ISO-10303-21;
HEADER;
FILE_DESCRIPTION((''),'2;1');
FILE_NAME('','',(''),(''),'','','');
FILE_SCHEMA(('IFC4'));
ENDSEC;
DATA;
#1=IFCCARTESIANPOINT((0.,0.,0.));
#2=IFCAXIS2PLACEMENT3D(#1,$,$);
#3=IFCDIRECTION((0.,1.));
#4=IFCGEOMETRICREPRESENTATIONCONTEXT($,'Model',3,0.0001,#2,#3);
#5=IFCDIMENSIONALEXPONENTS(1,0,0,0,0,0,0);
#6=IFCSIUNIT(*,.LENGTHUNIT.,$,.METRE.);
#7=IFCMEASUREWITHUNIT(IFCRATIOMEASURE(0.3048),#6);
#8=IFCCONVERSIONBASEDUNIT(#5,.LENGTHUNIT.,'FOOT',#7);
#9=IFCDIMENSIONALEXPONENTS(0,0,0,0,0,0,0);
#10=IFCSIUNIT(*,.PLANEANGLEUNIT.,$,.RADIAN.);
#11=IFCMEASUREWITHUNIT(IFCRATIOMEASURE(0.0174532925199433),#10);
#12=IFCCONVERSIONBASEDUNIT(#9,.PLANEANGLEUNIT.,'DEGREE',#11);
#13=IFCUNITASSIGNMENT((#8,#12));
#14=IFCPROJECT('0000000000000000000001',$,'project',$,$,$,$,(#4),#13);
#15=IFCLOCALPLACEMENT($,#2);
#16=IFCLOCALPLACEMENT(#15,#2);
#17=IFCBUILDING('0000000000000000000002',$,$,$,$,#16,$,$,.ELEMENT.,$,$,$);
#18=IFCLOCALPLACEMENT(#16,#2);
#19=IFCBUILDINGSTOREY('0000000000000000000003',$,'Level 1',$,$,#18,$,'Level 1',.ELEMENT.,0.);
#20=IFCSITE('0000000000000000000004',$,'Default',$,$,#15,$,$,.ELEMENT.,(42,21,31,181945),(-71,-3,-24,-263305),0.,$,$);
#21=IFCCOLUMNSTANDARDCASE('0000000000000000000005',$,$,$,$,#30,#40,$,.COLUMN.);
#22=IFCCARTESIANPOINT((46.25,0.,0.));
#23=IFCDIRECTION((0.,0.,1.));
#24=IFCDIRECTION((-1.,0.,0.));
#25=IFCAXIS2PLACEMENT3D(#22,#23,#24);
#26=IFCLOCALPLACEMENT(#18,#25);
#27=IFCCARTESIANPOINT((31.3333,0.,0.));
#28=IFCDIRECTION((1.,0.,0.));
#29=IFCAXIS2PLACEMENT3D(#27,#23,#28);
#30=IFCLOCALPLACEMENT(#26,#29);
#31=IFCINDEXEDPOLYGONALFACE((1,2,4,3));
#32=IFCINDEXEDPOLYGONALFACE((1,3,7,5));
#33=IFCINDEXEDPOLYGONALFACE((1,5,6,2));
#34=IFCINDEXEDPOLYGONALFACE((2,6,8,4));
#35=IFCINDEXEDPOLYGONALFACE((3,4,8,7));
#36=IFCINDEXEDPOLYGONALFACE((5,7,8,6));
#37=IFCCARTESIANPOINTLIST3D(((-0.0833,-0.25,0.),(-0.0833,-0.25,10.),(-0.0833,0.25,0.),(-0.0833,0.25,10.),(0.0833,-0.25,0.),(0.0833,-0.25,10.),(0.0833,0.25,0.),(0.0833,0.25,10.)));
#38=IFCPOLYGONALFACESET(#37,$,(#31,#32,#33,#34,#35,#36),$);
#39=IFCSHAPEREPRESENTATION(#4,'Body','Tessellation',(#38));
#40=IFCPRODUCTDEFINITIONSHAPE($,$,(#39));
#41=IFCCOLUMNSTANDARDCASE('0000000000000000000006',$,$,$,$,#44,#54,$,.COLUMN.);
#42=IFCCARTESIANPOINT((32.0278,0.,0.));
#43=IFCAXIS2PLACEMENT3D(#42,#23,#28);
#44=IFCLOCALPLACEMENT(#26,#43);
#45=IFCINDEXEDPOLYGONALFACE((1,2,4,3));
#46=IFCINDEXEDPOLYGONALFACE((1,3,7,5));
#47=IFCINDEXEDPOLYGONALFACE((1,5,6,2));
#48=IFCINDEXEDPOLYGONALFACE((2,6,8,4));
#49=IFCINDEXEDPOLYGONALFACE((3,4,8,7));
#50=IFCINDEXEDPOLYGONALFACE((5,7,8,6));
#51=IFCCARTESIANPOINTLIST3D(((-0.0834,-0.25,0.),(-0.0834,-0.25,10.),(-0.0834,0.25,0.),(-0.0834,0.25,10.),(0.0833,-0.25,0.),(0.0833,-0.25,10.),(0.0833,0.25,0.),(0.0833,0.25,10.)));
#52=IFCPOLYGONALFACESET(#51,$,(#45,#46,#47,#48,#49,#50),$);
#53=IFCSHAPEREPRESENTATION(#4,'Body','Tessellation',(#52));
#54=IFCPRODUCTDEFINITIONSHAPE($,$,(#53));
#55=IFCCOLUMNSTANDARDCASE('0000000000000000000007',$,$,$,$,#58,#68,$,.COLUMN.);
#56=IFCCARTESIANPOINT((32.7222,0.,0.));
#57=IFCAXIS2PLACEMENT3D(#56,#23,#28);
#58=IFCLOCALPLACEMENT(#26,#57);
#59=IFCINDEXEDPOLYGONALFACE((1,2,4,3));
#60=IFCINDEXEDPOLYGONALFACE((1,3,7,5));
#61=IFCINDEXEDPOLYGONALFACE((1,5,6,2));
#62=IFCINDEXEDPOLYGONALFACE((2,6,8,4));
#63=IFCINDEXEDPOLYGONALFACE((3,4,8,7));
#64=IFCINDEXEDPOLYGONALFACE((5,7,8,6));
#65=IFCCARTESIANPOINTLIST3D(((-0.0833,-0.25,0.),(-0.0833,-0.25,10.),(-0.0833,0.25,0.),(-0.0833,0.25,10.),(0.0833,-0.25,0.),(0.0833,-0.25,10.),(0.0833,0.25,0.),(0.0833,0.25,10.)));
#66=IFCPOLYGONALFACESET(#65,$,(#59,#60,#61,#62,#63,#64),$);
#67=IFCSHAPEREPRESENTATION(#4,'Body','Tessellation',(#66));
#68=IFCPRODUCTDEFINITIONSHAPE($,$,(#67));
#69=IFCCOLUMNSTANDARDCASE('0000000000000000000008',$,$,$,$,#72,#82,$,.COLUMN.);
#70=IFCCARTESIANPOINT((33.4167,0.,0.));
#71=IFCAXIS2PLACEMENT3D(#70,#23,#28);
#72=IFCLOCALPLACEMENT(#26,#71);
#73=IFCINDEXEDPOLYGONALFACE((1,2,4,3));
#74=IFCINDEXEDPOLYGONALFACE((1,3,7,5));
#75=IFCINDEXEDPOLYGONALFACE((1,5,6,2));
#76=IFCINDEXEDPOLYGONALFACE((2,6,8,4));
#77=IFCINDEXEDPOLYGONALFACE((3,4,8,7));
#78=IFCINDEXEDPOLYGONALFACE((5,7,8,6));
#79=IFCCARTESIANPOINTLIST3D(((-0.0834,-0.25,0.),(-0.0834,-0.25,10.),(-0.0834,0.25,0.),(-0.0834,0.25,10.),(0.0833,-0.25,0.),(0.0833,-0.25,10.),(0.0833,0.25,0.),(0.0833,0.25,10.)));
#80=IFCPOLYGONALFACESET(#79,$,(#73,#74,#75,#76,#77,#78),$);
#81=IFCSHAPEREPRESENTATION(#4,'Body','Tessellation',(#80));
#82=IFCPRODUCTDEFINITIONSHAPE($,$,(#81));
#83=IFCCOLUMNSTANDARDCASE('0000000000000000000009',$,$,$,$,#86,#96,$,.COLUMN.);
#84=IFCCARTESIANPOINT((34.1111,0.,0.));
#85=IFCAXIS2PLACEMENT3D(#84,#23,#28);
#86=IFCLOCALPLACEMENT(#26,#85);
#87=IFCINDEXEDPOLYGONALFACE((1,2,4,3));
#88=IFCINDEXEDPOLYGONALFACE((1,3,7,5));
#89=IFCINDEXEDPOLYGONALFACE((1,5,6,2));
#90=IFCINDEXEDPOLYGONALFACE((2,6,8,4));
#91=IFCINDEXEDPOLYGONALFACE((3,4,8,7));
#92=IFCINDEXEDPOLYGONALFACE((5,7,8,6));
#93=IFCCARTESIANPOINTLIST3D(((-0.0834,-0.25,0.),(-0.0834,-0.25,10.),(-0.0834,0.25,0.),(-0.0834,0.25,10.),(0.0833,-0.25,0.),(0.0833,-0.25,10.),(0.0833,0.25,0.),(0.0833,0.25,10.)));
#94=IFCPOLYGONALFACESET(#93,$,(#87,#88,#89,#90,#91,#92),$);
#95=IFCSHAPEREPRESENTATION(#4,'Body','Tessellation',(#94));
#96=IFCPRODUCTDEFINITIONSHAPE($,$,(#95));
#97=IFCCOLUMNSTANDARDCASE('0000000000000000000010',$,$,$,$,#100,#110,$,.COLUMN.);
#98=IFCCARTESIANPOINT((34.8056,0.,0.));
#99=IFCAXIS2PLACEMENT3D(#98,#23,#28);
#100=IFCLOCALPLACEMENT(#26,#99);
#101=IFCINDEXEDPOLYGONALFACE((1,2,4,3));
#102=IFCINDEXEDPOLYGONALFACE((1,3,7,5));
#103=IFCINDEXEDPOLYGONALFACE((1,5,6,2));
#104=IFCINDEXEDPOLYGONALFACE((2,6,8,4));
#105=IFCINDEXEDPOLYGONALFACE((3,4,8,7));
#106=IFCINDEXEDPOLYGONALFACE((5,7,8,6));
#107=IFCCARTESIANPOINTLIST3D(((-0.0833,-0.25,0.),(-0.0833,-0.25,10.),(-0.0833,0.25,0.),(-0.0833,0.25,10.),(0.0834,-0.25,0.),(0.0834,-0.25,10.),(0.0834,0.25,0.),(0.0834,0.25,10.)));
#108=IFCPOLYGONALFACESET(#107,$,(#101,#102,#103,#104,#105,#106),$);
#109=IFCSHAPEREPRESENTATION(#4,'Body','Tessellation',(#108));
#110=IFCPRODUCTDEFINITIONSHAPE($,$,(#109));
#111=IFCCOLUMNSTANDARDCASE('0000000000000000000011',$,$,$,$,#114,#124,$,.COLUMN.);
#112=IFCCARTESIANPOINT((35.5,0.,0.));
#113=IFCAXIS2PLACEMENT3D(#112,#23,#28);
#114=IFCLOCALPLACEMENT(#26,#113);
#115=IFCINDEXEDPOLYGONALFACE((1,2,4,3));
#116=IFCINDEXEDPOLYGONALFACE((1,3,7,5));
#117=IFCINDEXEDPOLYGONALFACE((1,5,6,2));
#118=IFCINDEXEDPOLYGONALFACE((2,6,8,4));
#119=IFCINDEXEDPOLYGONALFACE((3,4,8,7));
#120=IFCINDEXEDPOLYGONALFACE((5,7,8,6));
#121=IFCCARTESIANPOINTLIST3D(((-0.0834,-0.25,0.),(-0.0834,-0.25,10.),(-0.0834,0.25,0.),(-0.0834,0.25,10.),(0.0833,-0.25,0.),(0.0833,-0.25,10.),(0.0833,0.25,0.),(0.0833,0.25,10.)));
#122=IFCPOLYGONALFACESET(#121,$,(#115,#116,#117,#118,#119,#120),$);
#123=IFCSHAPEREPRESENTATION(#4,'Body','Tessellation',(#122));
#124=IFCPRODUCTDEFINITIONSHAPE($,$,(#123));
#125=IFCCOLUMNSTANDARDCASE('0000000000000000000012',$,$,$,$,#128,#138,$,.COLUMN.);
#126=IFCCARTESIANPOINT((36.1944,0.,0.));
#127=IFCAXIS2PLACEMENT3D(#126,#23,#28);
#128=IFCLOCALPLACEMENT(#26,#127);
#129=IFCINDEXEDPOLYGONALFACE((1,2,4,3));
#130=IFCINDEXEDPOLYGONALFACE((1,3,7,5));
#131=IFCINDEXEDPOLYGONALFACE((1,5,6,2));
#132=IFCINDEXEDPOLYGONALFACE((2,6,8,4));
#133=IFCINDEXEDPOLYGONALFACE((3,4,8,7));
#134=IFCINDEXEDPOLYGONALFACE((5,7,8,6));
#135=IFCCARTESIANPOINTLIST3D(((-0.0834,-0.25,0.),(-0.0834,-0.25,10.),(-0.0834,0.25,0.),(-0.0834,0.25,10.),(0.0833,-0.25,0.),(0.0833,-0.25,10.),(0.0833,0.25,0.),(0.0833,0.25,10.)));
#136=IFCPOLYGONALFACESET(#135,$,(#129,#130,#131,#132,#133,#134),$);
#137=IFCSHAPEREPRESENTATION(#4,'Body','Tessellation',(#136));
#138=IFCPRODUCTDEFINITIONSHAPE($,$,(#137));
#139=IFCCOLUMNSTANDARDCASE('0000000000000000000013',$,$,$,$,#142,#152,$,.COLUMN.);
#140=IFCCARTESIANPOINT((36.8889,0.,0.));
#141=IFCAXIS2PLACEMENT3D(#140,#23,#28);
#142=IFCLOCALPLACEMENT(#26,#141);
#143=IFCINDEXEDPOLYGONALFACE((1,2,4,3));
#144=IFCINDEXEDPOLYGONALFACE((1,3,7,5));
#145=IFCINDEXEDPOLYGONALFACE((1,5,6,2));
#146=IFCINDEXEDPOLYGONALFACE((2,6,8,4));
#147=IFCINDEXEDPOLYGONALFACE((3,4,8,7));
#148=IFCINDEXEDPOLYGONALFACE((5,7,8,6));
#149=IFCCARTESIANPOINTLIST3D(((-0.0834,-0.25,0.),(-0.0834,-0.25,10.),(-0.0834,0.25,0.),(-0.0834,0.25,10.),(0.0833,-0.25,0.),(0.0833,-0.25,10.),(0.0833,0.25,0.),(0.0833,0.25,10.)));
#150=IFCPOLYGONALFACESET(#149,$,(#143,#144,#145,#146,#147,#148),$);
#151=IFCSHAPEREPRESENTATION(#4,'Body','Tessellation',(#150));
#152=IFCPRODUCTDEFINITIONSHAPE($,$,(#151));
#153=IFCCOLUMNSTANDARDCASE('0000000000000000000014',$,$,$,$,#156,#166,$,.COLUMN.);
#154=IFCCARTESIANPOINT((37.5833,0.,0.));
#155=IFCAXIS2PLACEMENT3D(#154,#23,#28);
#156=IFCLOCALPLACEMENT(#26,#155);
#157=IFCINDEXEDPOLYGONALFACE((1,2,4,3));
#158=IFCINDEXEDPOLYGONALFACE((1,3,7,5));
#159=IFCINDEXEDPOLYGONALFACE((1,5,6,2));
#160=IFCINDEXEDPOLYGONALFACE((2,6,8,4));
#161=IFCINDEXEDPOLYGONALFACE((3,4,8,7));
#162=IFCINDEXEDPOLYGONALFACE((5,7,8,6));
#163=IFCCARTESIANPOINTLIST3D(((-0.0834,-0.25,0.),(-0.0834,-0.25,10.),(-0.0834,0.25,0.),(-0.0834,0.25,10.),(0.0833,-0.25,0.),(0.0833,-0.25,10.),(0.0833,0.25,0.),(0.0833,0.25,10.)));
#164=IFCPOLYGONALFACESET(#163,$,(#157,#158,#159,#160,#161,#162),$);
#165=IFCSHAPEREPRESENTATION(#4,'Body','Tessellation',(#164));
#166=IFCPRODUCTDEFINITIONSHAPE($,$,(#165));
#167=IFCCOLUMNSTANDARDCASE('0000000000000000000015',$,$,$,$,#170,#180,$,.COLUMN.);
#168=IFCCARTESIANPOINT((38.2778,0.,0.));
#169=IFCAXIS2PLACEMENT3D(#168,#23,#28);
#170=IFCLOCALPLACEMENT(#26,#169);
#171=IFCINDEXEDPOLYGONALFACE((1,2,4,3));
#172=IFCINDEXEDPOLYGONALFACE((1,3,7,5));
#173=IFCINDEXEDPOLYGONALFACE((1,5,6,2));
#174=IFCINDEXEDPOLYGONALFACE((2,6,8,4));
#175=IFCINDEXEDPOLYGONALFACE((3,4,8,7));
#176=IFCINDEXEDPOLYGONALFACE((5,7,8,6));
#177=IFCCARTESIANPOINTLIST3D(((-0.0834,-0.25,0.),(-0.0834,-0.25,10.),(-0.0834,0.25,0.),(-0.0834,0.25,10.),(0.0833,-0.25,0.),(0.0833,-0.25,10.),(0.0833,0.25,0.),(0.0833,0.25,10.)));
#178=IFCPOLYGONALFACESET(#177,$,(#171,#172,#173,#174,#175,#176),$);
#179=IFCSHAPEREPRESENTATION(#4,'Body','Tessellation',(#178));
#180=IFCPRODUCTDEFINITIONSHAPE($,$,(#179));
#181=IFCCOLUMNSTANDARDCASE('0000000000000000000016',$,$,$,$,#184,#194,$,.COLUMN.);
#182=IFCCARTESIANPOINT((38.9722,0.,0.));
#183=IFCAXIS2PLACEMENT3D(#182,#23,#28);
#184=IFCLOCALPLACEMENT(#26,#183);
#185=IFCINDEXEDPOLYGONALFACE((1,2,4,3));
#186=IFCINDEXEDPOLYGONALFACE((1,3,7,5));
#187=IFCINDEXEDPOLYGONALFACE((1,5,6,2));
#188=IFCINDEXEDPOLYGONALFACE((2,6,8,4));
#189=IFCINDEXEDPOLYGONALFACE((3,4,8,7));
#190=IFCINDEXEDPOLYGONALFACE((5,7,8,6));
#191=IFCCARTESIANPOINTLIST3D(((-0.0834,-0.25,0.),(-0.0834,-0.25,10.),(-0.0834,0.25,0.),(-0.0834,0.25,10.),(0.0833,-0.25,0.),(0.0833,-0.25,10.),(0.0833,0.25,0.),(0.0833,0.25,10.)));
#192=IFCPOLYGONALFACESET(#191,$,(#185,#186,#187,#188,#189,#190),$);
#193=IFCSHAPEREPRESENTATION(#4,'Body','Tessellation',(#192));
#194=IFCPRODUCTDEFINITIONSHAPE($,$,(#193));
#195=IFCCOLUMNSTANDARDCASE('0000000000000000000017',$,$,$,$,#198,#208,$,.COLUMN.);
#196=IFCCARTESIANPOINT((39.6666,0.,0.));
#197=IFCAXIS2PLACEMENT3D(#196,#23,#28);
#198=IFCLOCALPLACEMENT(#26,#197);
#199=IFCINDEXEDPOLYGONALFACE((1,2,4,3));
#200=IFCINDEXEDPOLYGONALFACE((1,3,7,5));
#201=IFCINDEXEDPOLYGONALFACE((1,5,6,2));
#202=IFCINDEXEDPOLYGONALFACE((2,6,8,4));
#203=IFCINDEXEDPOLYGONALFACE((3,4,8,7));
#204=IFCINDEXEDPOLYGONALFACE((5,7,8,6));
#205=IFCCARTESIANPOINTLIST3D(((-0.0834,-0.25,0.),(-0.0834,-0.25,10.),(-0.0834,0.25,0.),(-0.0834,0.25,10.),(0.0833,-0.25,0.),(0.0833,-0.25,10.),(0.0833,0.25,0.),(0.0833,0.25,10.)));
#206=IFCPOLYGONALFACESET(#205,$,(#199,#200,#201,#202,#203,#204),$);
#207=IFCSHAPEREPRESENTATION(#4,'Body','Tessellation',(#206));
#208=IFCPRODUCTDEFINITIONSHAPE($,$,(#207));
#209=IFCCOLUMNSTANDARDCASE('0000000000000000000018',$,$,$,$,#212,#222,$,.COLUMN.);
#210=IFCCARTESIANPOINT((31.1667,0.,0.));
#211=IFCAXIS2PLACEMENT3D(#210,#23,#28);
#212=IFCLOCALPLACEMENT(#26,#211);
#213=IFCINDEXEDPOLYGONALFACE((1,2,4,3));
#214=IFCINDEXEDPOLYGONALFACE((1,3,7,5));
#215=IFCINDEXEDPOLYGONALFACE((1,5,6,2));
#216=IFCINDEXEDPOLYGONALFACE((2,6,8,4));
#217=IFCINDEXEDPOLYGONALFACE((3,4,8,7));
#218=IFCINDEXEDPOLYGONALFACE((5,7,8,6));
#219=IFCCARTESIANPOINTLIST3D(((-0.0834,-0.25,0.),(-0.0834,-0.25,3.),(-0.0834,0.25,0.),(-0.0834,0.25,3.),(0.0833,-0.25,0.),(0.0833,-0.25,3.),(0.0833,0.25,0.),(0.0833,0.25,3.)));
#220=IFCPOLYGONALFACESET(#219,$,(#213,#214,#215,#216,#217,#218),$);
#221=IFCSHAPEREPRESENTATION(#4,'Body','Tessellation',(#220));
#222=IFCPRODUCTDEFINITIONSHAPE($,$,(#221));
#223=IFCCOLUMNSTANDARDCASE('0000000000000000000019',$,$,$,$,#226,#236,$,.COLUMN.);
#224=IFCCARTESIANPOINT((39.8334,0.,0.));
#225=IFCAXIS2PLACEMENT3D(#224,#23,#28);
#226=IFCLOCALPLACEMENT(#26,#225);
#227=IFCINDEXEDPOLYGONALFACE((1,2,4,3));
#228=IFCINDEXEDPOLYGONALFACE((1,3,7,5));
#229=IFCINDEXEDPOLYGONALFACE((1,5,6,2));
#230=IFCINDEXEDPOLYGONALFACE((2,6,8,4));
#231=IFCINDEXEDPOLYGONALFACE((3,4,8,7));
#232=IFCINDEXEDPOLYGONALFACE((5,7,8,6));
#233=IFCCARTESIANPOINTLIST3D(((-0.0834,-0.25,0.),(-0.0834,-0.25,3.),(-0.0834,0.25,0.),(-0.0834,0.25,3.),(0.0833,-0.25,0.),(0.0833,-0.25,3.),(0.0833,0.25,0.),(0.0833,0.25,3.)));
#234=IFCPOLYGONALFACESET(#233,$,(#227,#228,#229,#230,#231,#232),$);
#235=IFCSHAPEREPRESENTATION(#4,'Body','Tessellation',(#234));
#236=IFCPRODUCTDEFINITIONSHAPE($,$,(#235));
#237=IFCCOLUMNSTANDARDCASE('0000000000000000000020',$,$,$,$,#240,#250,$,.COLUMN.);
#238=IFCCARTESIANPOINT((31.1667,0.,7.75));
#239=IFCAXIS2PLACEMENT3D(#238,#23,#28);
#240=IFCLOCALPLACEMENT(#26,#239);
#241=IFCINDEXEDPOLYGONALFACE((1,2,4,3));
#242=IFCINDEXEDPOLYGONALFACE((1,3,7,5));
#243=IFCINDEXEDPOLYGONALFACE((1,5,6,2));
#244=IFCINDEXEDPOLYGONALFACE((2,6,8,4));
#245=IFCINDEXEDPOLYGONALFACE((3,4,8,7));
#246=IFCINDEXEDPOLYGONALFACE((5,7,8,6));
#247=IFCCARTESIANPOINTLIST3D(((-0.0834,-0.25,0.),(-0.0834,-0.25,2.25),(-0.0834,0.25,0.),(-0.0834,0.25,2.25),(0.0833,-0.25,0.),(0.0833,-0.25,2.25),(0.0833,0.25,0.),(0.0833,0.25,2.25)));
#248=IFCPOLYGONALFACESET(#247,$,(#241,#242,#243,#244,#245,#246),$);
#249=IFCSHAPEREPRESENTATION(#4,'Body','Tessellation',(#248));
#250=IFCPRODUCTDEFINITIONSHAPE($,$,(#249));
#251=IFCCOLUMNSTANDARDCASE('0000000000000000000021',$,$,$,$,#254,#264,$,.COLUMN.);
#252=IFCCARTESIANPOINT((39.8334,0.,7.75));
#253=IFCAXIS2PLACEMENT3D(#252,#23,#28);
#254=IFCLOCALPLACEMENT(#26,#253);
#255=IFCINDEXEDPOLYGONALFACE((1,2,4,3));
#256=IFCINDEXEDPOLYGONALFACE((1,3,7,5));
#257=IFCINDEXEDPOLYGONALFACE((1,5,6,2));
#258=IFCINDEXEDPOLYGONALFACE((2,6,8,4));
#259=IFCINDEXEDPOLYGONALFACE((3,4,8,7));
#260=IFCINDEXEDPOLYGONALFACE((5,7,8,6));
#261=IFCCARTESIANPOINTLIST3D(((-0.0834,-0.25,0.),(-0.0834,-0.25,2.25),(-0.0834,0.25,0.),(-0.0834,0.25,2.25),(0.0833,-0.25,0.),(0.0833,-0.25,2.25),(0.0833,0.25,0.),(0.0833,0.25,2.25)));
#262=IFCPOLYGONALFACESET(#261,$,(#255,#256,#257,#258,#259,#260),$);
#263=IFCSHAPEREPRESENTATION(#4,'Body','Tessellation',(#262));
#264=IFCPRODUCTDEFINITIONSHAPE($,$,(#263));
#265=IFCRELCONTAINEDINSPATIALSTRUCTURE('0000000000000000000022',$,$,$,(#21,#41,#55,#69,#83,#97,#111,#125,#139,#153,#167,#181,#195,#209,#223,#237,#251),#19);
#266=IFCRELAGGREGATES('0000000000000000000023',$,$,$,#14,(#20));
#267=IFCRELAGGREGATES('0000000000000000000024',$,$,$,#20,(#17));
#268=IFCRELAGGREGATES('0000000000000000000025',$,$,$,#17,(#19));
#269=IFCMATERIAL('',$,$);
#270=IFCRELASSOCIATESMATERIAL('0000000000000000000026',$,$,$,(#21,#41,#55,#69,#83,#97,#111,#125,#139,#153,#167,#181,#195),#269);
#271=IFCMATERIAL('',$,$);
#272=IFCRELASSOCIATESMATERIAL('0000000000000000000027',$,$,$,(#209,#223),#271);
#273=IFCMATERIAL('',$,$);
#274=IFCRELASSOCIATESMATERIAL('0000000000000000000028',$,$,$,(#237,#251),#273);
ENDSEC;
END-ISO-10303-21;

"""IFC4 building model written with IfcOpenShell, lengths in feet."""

from ifc_helpers import new_model, entity, si_unit, converted_unit, direction, frame, origin, place, context, project, spatial, rectangle, extrude, material, element, save


model = new_model("IFC4")

# Units and contexts
model_context = context("Model", 3, precision=0.0001, world=origin(), true_north=direction((0.0, 1.0)))
ifc_project = project(units=[converted_unit("LENGTHUNIT", "FOOT", entity("IfcRatioMeasure", 0.3048), si_unit("LENGTHUNIT", "METRE"), dimensions=[1, 0, 0, 0, 0, 0, 0]), converted_unit("PLANEANGLEUNIT", "DEGREE", entity("IfcRatioMeasure", 0.0174532925199433), si_unit("PLANEANGLEUNIT", "RADIAN"), dimensions=[0, 0, 0, 0, 0, 0, 0])], contexts=[model_context])

# Site, building, storey
site_placement = place(None, origin())
site = spatial("IfcSite", under=ifc_project, at=site_placement, Name="Default", CompositionType="ELEMENT", RefLatitude=(42, 21, 31, 181945), RefLongitude=(-71, -3, -24, -263305), RefElevation=0.0)
building_placement = place(site_placement, origin())
building = spatial("IfcBuilding", under=site, at=building_placement, CompositionType="ELEMENT")
storey_placement = place(building_placement, origin())
storey = spatial("IfcBuildingStorey", under=building, at=storey_placement, Name="Level 1", LongName="Level 1", CompositionType="ELEMENT", Elevation=0.0)

# Columns
ifc_material_1 = material(Name="")
placement_1 = place(storey_placement, frame((46.25, 0.0, 0.0), z_axis=(0.0, 0.0, 1.0), x_axis=(-1.0, 0.0, 0.0)))
for number, where, z_axis, x_axis in (
    (1, (31.3333, 0.0, 0.0), (0.0, 0.0, 1.0), (1.0, 0.0, 0.0)),
    (2, (32.0278, 0.0, 0.0), (0.0, 0.0, 1.0), (1.0, 0.0, 0.0)),
    (3, (32.7222, 0.0, 0.0), (0.0, 0.0, 1.0), (1.0, 0.0, 0.0)),
    (4, (33.4167, 0.0, 0.0), (0.0, 0.0, 1.0), (1.0, 0.0, 0.0)),
    (5, (34.1111, 0.0, 0.0), (0.0, 0.0, 1.0), (1.0, 0.0, 0.0)),
    (6, (34.8056, 0.0, 0.0), (0.0, 0.0, 1.0), (1.0, 0.0, 0.0)),
    (7, (35.5, 0.0, 0.0), (0.0, 0.0, 1.0), (1.0, 0.0, 0.0)),
    (8, (36.1944, 0.0, 0.0), (0.0, 0.0, 1.0), (1.0, 0.0, 0.0)),
    (9, (36.8889, 0.0, 0.0), (0.0, 0.0, 1.0), (1.0, 0.0, 0.0)),
    (10, (37.5833, 0.0, 0.0), (0.0, 0.0, 1.0), (1.0, 0.0, 0.0)),
    (11, (38.2778, 0.0, 0.0), (0.0, 0.0, 1.0), (1.0, 0.0, 0.0)),
    (12, (38.9722, 0.0, 0.0), (0.0, 0.0, 1.0), (1.0, 0.0, 0.0)),
    (13, (39.6666, 0.0, 0.0), (0.0, 0.0, 1.0), (1.0, 0.0, 0.0)),
):
    element("IfcColumnStandardCase", number, at=place(placement_1, frame(where, z_axis=z_axis, x_axis=x_axis)), inside=storey, material=ifc_material_1, PredefinedType="COLUMN", context=model_context, shape_type="SweptSolid", body=[
        extrude(rectangle(XDim=0.1667, YDim=0.5), origin(), (0.0, 0.0, 1.0), 10.0),
    ])
ifc_material_2 = material(Name="")
for number, where, z_axis, x_axis in (
    (14, (31.1667, 0.0, 0.0), (0.0, 0.0, 1.0), (1.0, 0.0, 0.0)),
    (15, (39.8334, 0.0, 0.0), (0.0, 0.0, 1.0), (1.0, 0.0, 0.0)),
):
    element("IfcColumnStandardCase", number, at=place(placement_1, frame(where, z_axis=z_axis, x_axis=x_axis)), inside=storey, material=ifc_material_2, PredefinedType="COLUMN", context=model_context, shape_type="SweptSolid", body=[
        extrude(rectangle(XDim=0.1667, YDim=0.5), origin(), (0.0, 0.0, 1.0), 3.0),
    ])
ifc_material_3 = material(Name="")
for number, where, z_axis, x_axis in (
    (16, (31.1667, 0.0, 7.75), (0.0, 0.0, 1.0), (1.0, 0.0, 0.0)),
    (17, (39.8334, 0.0, 7.75), (0.0, 0.0, 1.0), (1.0, 0.0, 0.0)),
):
    element("IfcColumnStandardCase", number, at=place(placement_1, frame(where, z_axis=z_axis, x_axis=x_axis)), inside=storey, material=ifc_material_3, PredefinedType="COLUMN", context=model_context, shape_type="SweptSolid", body=[
        extrude(rectangle(XDim=0.1667, YDim=0.5), origin(), (0.0, 0.0, 1.0), 2.25),
    ])

save(model, "model.ifc")
